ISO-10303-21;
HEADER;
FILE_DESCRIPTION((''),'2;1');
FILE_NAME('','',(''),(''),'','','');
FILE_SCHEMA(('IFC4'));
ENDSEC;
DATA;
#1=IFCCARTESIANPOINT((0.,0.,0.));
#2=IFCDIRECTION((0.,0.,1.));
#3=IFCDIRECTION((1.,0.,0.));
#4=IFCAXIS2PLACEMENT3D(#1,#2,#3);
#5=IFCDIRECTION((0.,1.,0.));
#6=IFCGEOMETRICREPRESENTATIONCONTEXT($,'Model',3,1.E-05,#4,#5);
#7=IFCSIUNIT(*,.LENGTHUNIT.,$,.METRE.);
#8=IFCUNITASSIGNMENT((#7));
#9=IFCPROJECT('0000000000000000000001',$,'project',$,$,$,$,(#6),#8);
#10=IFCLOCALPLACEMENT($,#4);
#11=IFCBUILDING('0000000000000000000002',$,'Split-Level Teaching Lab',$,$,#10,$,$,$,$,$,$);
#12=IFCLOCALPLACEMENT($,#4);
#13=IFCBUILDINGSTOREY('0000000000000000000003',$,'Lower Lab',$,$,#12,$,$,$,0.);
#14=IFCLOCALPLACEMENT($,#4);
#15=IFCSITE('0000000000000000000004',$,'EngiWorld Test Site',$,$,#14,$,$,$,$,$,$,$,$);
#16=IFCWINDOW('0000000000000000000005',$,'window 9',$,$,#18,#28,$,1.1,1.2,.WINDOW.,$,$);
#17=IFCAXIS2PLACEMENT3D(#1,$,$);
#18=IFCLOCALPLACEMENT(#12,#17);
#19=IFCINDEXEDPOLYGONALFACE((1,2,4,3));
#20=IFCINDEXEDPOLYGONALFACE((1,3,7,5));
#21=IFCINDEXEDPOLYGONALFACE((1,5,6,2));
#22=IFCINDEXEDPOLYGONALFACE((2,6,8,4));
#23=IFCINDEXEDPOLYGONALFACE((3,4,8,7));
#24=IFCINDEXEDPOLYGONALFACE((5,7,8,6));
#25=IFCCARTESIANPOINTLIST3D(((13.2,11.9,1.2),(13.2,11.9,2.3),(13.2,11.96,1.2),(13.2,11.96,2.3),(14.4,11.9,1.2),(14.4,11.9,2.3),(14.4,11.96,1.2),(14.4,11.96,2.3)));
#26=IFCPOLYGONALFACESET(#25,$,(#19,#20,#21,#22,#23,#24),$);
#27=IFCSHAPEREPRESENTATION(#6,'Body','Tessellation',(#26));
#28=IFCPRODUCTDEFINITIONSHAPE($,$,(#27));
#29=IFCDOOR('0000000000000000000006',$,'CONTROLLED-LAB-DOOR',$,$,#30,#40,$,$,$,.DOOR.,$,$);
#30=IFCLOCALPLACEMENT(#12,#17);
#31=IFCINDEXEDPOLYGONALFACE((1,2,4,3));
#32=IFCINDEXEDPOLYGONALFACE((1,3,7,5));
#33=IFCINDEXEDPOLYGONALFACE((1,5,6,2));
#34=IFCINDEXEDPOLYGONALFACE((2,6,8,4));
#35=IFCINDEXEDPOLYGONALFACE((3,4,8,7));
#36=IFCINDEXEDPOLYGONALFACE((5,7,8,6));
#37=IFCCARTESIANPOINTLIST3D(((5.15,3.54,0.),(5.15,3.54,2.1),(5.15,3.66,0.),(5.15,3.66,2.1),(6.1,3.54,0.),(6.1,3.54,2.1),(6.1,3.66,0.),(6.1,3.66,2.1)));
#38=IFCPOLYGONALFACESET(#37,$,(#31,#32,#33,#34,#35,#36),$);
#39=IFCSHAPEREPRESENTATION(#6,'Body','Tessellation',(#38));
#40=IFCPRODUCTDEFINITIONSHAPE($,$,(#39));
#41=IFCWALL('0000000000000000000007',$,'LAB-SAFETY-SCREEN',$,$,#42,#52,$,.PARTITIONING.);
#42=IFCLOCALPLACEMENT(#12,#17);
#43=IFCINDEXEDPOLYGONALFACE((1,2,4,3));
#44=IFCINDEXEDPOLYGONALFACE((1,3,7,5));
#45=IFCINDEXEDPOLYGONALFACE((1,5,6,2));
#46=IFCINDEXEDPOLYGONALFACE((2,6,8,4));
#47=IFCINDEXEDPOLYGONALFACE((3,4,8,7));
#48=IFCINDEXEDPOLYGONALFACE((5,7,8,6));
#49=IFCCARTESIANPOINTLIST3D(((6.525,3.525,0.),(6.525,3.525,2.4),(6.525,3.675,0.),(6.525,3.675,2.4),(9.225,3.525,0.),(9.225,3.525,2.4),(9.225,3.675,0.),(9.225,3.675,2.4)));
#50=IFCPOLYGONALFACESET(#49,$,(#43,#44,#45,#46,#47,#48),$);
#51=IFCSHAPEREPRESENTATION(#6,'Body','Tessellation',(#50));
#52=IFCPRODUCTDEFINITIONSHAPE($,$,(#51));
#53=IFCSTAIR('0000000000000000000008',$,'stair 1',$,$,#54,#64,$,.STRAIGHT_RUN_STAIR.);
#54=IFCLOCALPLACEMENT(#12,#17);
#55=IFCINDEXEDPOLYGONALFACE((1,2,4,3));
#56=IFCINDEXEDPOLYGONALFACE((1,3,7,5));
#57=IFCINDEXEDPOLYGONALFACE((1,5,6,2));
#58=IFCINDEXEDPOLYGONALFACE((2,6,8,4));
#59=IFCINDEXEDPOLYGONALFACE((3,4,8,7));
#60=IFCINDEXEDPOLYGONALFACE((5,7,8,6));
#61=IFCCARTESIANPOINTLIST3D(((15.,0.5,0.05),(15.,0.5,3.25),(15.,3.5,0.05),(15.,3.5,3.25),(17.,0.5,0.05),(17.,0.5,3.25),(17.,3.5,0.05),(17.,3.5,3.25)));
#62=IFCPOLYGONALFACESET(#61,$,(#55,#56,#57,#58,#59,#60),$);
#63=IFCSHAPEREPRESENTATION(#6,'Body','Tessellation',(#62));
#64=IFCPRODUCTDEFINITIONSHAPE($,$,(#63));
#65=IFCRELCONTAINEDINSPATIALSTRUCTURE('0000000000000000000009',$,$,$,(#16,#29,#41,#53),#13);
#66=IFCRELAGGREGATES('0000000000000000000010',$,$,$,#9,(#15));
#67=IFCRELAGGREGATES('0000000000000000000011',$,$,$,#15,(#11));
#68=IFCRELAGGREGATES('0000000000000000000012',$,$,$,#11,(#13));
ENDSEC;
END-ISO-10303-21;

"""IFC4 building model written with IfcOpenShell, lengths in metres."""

from ifc_helpers import new_model, si_unit, direction, frame, origin, origin_with_axes, origin_2d, origin_2d_with_axis, place, context, project, spatial, rectangle, extrude, element, save


model = new_model("IFC4")

# Units and contexts
model_context = context("Model", 3, precision=1e-05, world=origin_with_axes(), true_north=direction((0.0, 1.0, 0.0)))
ifc_project = project(units=[si_unit("LENGTHUNIT", "METRE")], contexts=[model_context])

# Site, building, storey
site_placement = place(None, origin_with_axes())
site = spatial("IfcSite", under=ifc_project, at=site_placement, Name="EngiWorld Test Site")
building_placement = place(None, origin_with_axes())
building = spatial("IfcBuilding", under=site, at=building_placement, Name="Split-Level Teaching Lab")
storey_placement = place(None, origin_with_axes())
storey = spatial("IfcBuildingStorey", under=building, at=storey_placement, Name="Lower Lab", Elevation=0.0)

# Window
for number, where, z_axis, x_axis, name in (
    (1, (13.8, 11.93, 1.2), (0.0, 0.0, 1.0), (1.0, 0.0, 0.0), "window 9"),
):
    element("IfcWindow", number, at=place(None, frame(where, z_axis=z_axis, x_axis=x_axis)), inside=storey, Name=name, OverallHeight=1.1, OverallWidth=1.2, PredefinedType="WINDOW", context=model_context, shape_type="SweptSolid", body=[
        extrude(rectangle(XDim=1.2, YDim=0.06, at=origin_2d_with_axis()), origin_with_axes(), (0.0, 0.0, 1.0), 1.1),
    ])

# Door
door_placement = place(None, frame((5.625, 3.6, 0.0)))
element("IfcDoor", 2, at=door_placement, inside=storey, Name="CONTROLLED-LAB-DOOR", PredefinedType="DOOR", context=model_context, shape_type="SweptSolid", body=[
    extrude(rectangle(XDim=0.95, YDim=0.12, at=origin_2d()), origin(), (0.0, 0.0, 1.0), 2.1),
])

# Wall
wall_1_placement = place(None, frame((7.875, 3.6, 0.0)))
element("IfcWall", 3, at=wall_1_placement, inside=storey, Name="LAB-SAFETY-SCREEN", PredefinedType="PARTITIONING", context=model_context, shape_type="SweptSolid", body=[
    extrude(rectangle(XDim=2.7, YDim=0.15, at=origin_2d()), origin(), (0.0, 0.0, 1.0), 2.4),
])

# Stair
stair_placement = place(None, frame((16.0, 2.0, 0.05), z_axis=(0.0, 0.0, 1.0), x_axis=(1.0, 0.0, 0.0)))
element("IfcStair", 4, at=stair_placement, inside=storey, Name="stair 1", PredefinedType="STRAIGHT_RUN_STAIR", context=model_context, shape_type="SweptSolid", body=[
    extrude(rectangle(XDim=2.0, YDim=3.0, at=origin_2d_with_axis()), origin_with_axes(), (0.0, 0.0, 1.0), 3.2),
])

save(model, "model.ifc")
